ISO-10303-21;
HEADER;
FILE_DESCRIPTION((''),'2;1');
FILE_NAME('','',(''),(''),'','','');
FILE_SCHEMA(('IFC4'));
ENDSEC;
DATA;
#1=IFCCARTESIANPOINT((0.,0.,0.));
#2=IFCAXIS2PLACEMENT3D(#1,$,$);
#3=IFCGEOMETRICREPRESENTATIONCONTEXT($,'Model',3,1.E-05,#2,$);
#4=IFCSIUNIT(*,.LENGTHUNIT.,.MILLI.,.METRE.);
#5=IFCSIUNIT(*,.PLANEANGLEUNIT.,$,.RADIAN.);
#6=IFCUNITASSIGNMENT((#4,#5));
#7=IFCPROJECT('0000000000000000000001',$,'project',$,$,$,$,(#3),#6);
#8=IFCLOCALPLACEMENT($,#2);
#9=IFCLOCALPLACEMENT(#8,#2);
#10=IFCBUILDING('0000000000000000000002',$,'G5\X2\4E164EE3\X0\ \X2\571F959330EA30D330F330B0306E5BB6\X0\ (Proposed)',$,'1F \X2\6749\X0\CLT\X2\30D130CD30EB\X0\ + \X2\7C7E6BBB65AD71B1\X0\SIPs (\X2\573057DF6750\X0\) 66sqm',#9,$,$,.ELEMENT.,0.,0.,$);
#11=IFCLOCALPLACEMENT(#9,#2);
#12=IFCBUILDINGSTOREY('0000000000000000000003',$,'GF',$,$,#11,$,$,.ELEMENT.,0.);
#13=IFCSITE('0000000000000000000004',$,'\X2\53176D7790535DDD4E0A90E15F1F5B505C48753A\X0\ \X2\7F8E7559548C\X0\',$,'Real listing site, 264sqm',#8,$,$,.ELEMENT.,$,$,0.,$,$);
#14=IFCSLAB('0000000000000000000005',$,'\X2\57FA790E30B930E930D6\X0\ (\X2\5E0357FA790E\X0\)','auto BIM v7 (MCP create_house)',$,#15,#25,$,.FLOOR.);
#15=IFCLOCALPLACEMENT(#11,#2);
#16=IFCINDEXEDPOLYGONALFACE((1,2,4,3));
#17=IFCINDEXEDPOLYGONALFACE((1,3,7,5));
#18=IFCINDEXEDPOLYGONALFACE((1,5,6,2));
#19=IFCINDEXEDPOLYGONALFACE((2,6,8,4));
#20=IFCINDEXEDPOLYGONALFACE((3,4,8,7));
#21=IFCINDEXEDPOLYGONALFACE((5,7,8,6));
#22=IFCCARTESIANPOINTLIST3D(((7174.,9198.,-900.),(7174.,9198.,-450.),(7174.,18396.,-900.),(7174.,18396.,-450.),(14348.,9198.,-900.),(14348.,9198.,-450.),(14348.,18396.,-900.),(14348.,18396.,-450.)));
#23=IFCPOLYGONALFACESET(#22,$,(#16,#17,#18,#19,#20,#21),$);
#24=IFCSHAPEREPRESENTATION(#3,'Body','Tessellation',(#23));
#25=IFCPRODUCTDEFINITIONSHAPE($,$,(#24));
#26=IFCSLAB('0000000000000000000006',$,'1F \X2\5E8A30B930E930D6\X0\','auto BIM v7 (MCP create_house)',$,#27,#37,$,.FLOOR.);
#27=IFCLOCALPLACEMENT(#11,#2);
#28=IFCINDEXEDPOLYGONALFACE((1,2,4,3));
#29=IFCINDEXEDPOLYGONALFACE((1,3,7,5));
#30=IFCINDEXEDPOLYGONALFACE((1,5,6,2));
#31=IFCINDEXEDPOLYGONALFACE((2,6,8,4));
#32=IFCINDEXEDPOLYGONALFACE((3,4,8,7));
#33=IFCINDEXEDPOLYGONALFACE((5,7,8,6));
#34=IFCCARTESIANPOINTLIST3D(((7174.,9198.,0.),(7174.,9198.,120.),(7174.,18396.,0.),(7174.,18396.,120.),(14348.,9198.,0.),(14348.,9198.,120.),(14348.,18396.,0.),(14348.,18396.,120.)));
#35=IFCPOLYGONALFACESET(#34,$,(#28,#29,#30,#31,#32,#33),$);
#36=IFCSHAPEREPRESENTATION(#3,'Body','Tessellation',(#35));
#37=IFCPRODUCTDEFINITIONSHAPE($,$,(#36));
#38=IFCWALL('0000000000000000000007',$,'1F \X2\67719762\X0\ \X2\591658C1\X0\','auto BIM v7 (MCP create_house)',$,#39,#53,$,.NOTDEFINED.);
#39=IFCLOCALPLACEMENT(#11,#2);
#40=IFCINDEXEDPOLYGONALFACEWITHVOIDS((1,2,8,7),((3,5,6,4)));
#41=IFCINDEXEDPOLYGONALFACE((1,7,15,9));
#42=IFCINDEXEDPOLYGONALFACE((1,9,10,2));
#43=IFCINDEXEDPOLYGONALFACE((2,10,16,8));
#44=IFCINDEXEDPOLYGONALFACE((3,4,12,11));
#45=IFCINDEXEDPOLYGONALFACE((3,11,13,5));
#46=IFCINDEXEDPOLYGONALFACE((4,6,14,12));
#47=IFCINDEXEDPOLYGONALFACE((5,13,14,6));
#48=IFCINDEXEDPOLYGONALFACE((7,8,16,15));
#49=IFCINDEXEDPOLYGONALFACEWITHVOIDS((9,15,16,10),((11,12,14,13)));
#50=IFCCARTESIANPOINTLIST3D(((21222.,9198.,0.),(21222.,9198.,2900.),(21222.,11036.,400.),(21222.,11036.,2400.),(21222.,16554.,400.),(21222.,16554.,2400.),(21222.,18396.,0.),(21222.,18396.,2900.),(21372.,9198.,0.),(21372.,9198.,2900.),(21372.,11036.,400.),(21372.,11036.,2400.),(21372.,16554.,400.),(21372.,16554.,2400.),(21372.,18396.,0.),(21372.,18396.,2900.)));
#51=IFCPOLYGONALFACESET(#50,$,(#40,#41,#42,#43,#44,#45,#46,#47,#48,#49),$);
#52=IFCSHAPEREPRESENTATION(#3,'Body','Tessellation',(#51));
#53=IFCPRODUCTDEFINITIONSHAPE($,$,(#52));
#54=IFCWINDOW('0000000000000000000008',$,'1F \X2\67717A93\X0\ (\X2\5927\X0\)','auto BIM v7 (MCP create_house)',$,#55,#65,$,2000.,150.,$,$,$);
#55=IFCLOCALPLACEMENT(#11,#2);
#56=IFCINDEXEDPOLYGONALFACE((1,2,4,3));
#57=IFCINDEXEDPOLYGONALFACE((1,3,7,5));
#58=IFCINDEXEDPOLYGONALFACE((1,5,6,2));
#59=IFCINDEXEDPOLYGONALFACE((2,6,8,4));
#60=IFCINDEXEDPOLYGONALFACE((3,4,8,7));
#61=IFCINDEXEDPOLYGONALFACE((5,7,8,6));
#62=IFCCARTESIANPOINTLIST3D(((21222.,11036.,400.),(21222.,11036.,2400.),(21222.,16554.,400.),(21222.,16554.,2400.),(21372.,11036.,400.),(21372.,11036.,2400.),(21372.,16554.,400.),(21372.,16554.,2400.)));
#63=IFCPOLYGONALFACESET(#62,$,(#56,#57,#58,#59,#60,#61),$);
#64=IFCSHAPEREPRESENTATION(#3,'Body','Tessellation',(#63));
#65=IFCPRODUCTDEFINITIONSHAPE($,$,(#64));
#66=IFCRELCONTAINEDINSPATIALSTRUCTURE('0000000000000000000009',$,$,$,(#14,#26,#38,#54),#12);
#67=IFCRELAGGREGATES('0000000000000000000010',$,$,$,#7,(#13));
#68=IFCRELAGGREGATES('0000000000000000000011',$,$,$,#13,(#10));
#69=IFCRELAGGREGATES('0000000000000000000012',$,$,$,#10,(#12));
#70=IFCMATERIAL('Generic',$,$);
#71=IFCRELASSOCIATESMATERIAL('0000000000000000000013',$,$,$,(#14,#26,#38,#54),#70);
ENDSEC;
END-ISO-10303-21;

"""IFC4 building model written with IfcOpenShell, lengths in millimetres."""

from ifc_helpers import new_model, si_unit, frame, frame_2d, origin, place, context, project, spatial, rectangle, extrude, material, element, fill, save


model = new_model("IFC4")

# Units and contexts
model_context = context("Model", 3, precision=1e-05, world=origin())
ifc_project = project(units=[si_unit("LENGTHUNIT", "METRE", prefix="MILLI"), si_unit("PLANEANGLEUNIT", "RADIAN")], contexts=[model_context])

# Site, building, storey
site_placement = place(None, origin())
site = spatial("IfcSite", under=ifc_project, at=site_placement, Name="北海道川上郡弟子屈町 美留和", ObjectType="Real listing site, 264sqm", CompositionType="ELEMENT", RefElevation=0.0)
building_placement = place(site_placement, origin())
building = spatial("IfcBuilding", under=site, at=building_placement, Name="G5世代 土間リビングの家 (Proposed)", ObjectType="1F 杉CLTパネル + 籾殻断熱SIPs (地域材) 66sqm", CompositionType="ELEMENT", ElevationOfRefHeight=0.0, ElevationOfTerrain=0.0)
storey_placement = place(building_placement, origin())
storey = spatial("IfcBuildingStorey", under=building, at=storey_placement, Name="GF", CompositionType="ELEMENT", Elevation=0.0)

# Slabs
ifc_material = material(Name="Generic")
slab_1_placement = place(storey_placement, frame((3587.0, 4599.0, -450.0)))
element("IfcSlab", 1, at=slab_1_placement, inside=storey, material=ifc_material, Name="基礎スラブ (布基礎)", Description="auto BIM v7 (MCP create_house)", PredefinedType="FLOOR", context=model_context, shape_type="SweptSolid", body=[
    extrude(rectangle(XDim=7174.0, YDim=9198.0, at=frame_2d((3587.0, 4599.0))), frame((3587.0, 4599.0, -450.0)), (0.0, 0.0, 1.0), 450.0),
])
slab_2_placement = place(storey_placement, frame((3587.0, 4599.0, 0.0)))
element("IfcSlab", 2, at=slab_2_placement, inside=storey, material=ifc_material, Name="1F 床スラブ", Description="auto BIM v7 (MCP create_house)", PredefinedType="FLOOR", context=model_context, shape_type="SweptSolid", body=[
    extrude(rectangle(XDim=7174.0, YDim=9198.0, at=frame_2d((3587.0, 4599.0))), frame((3587.0, 4599.0, 0.0)), (0.0, 0.0, 1.0), 120.0),
])

# Wall, opening, window
wall_1_placement = place(storey_placement, frame((10611.0, 4599.0, 0.0)))
wall_1 = element("IfcWall", 3, at=wall_1_placement, inside=storey, material=ifc_material, Name="1F 東面 外壁", Description="auto BIM v7 (MCP create_house)", PredefinedType="NOTDEFINED", context=model_context, shape_type="SweptSolid", body=[
    extrude(rectangle(XDim=150.0, YDim=9198.0, at=frame_2d((75.0, 4599.0))), frame((10611.0, 4599.0, 0.0)), (0.0, 0.0, 1.0), 2900.0),
])
opening_1_placement = place(storey_placement, frame((10611.0, 5518.0, 200.0)))
opening_1 = element("IfcOpeningElement", 4, at=opening_1_placement, cuts=wall_1, PredefinedType="NOTDEFINED", context=model_context, shape_type="SweptSolid", body=[
    extrude(rectangle(XDim=150.0, YDim=5518.0, at=frame_2d((75.0, 2759.0))), frame((10611.0, 5518.0, 200.0)), (0.0, 0.0, 1.0), 2000.0),
])
window_1_placement = place(storey_placement, frame((10611.0, 5518.0, 200.0)))
window_1 = element("IfcWindow", 5, at=window_1_placement, inside=storey, material=ifc_material, Name="1F 東窓 (大)", Description="auto BIM v7 (MCP create_house)", OverallHeight=2000.0, OverallWidth=150.0, context=model_context, shape_type="SweptSolid", body=[
    extrude(rectangle(XDim=150.0, YDim=5518.0, at=frame_2d((75.0, 2759.0))), frame((10611.0, 5518.0, 200.0)), (0.0, 0.0, 1.0), 2000.0),
])
fill(opening_1, window_1)

save(model, "model.ifc")
